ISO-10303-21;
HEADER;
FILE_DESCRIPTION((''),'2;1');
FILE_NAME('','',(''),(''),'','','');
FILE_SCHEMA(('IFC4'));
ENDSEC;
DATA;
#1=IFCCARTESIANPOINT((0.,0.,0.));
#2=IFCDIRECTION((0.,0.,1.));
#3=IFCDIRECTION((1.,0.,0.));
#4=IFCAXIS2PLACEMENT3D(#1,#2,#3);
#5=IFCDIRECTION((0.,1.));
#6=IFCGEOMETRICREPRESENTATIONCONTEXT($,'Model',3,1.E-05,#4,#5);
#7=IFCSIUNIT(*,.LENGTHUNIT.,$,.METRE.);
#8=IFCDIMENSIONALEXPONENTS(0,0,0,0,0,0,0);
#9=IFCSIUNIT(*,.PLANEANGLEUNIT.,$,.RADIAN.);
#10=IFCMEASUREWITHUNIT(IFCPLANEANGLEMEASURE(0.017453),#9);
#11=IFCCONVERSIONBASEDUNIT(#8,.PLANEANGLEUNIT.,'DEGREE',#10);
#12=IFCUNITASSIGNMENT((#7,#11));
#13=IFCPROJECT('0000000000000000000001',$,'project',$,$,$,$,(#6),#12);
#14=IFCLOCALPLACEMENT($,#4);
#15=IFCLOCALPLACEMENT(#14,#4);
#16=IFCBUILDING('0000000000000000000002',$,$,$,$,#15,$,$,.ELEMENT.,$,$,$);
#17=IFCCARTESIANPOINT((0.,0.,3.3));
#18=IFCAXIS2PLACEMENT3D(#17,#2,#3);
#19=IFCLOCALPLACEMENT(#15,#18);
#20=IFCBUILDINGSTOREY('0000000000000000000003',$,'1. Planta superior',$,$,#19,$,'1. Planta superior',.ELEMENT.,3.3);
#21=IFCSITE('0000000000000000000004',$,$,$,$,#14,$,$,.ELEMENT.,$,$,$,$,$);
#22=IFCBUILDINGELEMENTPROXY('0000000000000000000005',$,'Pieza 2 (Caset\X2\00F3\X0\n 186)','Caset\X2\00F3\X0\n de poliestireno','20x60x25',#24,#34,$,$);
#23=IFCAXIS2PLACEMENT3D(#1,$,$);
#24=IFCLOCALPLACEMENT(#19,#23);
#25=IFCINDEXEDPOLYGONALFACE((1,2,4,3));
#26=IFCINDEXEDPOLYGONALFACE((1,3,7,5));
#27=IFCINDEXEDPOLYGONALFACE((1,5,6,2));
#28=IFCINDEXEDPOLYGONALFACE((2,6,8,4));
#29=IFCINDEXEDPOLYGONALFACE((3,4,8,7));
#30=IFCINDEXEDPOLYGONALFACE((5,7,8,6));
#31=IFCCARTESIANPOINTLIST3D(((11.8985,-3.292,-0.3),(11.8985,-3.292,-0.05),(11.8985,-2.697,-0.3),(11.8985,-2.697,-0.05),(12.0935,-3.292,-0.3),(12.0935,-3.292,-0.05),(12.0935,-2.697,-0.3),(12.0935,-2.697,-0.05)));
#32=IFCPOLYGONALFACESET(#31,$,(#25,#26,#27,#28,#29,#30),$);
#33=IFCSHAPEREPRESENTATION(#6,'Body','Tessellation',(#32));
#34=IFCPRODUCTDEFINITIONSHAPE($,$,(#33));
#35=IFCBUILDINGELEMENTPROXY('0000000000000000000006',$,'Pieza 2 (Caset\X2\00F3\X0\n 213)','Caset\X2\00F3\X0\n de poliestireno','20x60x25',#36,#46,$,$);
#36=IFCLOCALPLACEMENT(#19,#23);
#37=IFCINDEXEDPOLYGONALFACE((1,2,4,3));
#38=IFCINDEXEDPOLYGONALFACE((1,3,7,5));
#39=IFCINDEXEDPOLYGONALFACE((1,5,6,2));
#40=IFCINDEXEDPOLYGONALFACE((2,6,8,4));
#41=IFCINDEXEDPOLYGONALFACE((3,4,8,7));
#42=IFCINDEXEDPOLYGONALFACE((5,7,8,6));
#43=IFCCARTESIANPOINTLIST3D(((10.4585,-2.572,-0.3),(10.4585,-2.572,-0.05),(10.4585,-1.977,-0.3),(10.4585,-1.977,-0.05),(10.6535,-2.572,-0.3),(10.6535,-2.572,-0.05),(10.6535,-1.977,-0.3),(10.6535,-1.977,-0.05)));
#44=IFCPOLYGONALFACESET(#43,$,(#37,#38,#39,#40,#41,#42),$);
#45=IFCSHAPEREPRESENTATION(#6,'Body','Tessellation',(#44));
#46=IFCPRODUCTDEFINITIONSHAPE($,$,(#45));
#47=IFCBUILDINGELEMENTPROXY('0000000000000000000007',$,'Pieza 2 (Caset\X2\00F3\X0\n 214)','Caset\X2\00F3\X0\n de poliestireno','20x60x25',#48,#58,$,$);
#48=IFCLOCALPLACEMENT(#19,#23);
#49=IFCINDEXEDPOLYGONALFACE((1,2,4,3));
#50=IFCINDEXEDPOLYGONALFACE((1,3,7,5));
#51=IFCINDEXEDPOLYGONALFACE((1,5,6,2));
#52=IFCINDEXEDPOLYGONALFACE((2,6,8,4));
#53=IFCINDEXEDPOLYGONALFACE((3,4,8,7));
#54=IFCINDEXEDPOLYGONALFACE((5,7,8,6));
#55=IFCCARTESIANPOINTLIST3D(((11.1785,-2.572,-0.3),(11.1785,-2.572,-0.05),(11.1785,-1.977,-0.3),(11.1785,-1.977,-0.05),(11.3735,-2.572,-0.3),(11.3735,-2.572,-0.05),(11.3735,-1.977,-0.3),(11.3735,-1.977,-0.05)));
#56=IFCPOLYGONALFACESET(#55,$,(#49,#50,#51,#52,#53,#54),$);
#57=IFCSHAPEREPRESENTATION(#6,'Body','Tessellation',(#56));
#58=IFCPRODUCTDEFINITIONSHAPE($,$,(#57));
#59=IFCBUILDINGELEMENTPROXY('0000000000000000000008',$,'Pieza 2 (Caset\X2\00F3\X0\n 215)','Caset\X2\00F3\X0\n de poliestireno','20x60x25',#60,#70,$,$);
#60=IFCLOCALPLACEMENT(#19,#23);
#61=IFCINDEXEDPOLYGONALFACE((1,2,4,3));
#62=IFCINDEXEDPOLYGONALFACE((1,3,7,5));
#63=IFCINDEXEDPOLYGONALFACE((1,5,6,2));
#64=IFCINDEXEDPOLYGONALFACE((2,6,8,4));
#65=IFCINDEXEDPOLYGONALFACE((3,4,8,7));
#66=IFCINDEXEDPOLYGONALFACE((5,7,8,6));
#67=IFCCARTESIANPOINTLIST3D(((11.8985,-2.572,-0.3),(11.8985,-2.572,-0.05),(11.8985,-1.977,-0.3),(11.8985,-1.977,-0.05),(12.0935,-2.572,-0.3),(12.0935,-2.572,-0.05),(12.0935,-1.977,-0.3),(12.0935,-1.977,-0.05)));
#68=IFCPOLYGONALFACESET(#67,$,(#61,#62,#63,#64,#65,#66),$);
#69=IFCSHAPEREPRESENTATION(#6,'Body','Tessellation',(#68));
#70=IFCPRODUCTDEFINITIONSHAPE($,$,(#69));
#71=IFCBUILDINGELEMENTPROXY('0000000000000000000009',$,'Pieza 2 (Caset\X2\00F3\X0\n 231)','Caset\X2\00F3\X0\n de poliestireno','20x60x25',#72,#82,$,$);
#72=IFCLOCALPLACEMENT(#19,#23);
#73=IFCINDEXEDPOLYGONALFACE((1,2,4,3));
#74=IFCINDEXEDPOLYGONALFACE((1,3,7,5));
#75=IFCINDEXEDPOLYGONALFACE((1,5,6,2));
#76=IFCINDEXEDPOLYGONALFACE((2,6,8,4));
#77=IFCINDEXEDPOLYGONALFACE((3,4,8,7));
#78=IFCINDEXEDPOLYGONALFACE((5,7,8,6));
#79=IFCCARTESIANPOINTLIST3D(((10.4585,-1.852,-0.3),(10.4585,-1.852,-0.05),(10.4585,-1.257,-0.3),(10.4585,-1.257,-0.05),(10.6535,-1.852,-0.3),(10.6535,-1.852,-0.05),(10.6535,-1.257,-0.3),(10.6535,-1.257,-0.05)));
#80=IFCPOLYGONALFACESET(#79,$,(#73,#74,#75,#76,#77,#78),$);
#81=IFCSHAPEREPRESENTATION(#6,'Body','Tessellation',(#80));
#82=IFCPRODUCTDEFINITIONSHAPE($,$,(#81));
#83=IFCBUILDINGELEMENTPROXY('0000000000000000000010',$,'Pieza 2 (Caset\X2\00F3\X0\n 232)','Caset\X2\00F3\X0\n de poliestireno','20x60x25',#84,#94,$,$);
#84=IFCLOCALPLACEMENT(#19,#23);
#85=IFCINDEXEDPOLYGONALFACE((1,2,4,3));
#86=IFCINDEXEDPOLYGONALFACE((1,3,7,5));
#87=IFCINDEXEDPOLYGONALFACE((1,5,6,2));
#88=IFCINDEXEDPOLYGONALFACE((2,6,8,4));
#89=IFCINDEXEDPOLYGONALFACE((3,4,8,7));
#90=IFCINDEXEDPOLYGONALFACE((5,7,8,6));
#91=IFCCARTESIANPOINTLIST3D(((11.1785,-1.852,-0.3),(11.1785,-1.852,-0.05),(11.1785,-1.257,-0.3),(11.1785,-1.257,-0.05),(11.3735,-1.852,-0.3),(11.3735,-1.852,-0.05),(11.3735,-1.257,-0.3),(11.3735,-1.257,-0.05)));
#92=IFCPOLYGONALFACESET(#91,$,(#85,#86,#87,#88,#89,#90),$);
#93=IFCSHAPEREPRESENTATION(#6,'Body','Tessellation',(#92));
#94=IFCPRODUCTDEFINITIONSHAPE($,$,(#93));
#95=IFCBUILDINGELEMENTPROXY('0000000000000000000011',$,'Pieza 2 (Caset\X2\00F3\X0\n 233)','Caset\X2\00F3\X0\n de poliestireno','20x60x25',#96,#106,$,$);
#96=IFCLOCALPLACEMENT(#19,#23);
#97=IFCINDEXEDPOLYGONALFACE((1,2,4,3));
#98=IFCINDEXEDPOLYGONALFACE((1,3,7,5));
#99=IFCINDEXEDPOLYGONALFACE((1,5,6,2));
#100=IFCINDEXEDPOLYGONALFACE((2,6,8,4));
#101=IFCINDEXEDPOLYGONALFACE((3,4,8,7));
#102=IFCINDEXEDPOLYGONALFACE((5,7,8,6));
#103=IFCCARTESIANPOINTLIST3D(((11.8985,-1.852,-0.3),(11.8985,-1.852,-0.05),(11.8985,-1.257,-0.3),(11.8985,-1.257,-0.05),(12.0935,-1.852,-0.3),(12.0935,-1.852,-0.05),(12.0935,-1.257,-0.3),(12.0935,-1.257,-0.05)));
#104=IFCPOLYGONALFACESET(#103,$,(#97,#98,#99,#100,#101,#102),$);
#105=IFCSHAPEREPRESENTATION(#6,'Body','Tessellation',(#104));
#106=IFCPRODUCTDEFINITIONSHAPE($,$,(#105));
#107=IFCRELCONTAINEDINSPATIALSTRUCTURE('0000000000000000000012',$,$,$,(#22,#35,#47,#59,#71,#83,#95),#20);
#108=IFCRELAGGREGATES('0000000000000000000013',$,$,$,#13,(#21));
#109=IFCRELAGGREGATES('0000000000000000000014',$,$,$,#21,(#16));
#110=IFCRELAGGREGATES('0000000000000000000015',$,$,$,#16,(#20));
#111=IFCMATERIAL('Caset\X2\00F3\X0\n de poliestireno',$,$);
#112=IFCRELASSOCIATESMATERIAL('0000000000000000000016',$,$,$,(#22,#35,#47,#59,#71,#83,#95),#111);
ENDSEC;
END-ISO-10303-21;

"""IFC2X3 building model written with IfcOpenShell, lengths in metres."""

from ifc_helpers import new_model, entity, si_unit, converted_unit, direction, frame, origin_with_axes, origin_2d_with_axis, place, context, project, spatial, rectangle, extrude, source, transform, mapped, material, element, save


model = new_model("IFC2X3")

# Units and contexts
model_context = context("Model", 3, precision=1e-05, world=origin_with_axes(), true_north=direction((0.0, 1.0)))
ifc_project = project(units=[si_unit("LENGTHUNIT", "METRE"), converted_unit("PLANEANGLEUNIT", "DEGREE", entity("IfcPlaneAngleMeasure", 0.017453), si_unit("PLANEANGLEUNIT", "RADIAN"), dimensions=[0, 0, 0, 0, 0, 0, 0])], contexts=[model_context])

# Site, building, storey
site_placement = place(None, origin_with_axes())
site = spatial("IfcSite", under=ifc_project, at=site_placement, CompositionType="ELEMENT")
building_placement = place(site_placement, origin_with_axes())
building = spatial("IfcBuilding", under=site, at=building_placement, CompositionType="ELEMENT")
storey_placement = place(building_placement, frame((0.0, 0.0, 3.3), z_axis=(0.0, 0.0, 1.0), x_axis=(1.0, 0.0, 0.0)))
storey = spatial("IfcBuildingStorey", under=building, at=storey_placement, Name="1. Planta superior", LongName="1. Planta superior", CompositionType="ELEMENT", Elevation=3.3)

# Building element proxies
ifc_material = material(Name="Casetón de poliestireno")
shared_shape = source(origin_with_axes(), model_context, "Body", "SweptSolid", [
    extrude(rectangle(XDim=0.195, YDim=0.25, at=origin_2d_with_axis()), origin_with_axes(), (0.0, 0.0, 1.0), 0.595),
])
placement_1 = place(storey_placement, frame((11.996, -3.292, -0.175), z_axis=(0.0, 1.0, 0.0), x_axis=(-1.0, 0.0, 0.0)))
for number, where, z_axis, x_axis, name in (
    (1, (0.0, 0.0, 0.0), (0.0, 0.0, 1.0), (1.0, 0.0, 0.0), "Pieza 2 (Casetón 186)"),
):
    element("IfcBuildingElementProxy", number, at=place(placement_1, frame(where, z_axis=z_axis, x_axis=x_axis)), inside=storey, material=ifc_material, Name=name, Description="Casetón de poliestireno", ObjectType="20x60x25", context=model_context, shape_type="MappedRepresentation", body=[
        mapped(shared_shape, transform((0.0, 0.0, 0.0), x_axis=(1.0, 0.0, 0.0), y_axis=(0.0, 1.0, 0.0), z_axis=(0.0, 0.0, 1.0))),
    ])
placement_2 = place(storey_placement, frame((10.556, -2.572, -0.175), z_axis=(0.0, 1.0, 0.0), x_axis=(-1.0, 0.0, 0.0)))
for number, where, z_axis, x_axis, name in (
    (2, (0.0, 0.0, 0.0), (0.0, 0.0, 1.0), (1.0, 0.0, 0.0), "Pieza 2 (Casetón 213)"),
):
    element("IfcBuildingElementProxy", number, at=place(placement_2, frame(where, z_axis=z_axis, x_axis=x_axis)), inside=storey, material=ifc_material, Name=name, Description="Casetón de poliestireno", ObjectType="20x60x25", context=model_context, shape_type="MappedRepresentation", body=[
        mapped(shared_shape, transform((0.0, 0.0, 0.0), x_axis=(1.0, 0.0, 0.0), y_axis=(0.0, 1.0, 0.0), z_axis=(0.0, 0.0, 1.0))),
    ])
placement_3 = place(storey_placement, frame((11.276, -2.572, -0.175), z_axis=(0.0, 1.0, 0.0), x_axis=(-1.0, 0.0, 0.0)))
for number, where, z_axis, x_axis, name in (
    (3, (0.0, 0.0, 0.0), (0.0, 0.0, 1.0), (1.0, 0.0, 0.0), "Pieza 2 (Casetón 214)"),
):
    element("IfcBuildingElementProxy", number, at=place(placement_3, frame(where, z_axis=z_axis, x_axis=x_axis)), inside=storey, material=ifc_material, Name=name, Description="Casetón de poliestireno", ObjectType="20x60x25", context=model_context, shape_type="MappedRepresentation", body=[
        mapped(shared_shape, transform((0.0, 0.0, 0.0), x_axis=(1.0, 0.0, 0.0), y_axis=(0.0, 1.0, 0.0), z_axis=(0.0, 0.0, 1.0))),
    ])
placement_4 = place(storey_placement, frame((11.996, -2.572, -0.175), z_axis=(0.0, 1.0, 0.0), x_axis=(-1.0, 0.0, 0.0)))
for number, where, z_axis, x_axis, name in (
    (4, (0.0, 0.0, 0.0), (0.0, 0.0, 1.0), (1.0, 0.0, 0.0), "Pieza 2 (Casetón 215)"),
):
    element("IfcBuildingElementProxy", number, at=place(placement_4, frame(where, z_axis=z_axis, x_axis=x_axis)), inside=storey, material=ifc_material, Name=name, Description="Casetón de poliestireno", ObjectType="20x60x25", context=model_context, shape_type="MappedRepresentation", body=[
        mapped(shared_shape, transform((0.0, 0.0, 0.0), x_axis=(1.0, 0.0, 0.0), y_axis=(0.0, 1.0, 0.0), z_axis=(0.0, 0.0, 1.0))),
    ])
placement_5 = place(storey_placement, frame((10.556, -1.852, -0.175), z_axis=(0.0, 1.0, 0.0), x_axis=(-1.0, 0.0, 0.0)))
for number, where, z_axis, x_axis, name in (
    (5, (0.0, 0.0, 0.0), (0.0, 0.0, 1.0), (1.0, 0.0, 0.0), "Pieza 2 (Casetón 231)"),
):
    element("IfcBuildingElementProxy", number, at=place(placement_5, frame(where, z_axis=z_axis, x_axis=x_axis)), inside=storey, material=ifc_material, Name=name, Description="Casetón de poliestireno", ObjectType="20x60x25", context=model_context, shape_type="MappedRepresentation", body=[
        mapped(shared_shape, transform((0.0, 0.0, 0.0), x_axis=(1.0, 0.0, 0.0), y_axis=(0.0, 1.0, 0.0), z_axis=(0.0, 0.0, 1.0))),
    ])
placement_6 = place(storey_placement, frame((11.276, -1.852, -0.175), z_axis=(0.0, 1.0, 0.0), x_axis=(-1.0, 0.0, 0.0)))
for number, where, z_axis, x_axis, name in (
    (6, (0.0, 0.0, 0.0), (0.0, 0.0, 1.0), (1.0, 0.0, 0.0), "Pieza 2 (Casetón 232)"),
):
    element("IfcBuildingElementProxy", number, at=place(placement_6, frame(where, z_axis=z_axis, x_axis=x_axis)), inside=storey, material=ifc_material, Name=name, Description="Casetón de poliestireno", ObjectType="20x60x25", context=model_context, shape_type="MappedRepresentation", body=[
        mapped(shared_shape, transform((0.0, 0.0, 0.0), x_axis=(1.0, 0.0, 0.0), y_axis=(0.0, 1.0, 0.0), z_axis=(0.0, 0.0, 1.0))),
    ])
placement_7 = place(storey_placement, frame((11.996, -1.852, -0.175), z_axis=(0.0, 1.0, 0.0), x_axis=(-1.0, 0.0, 0.0)))
for number, where, z_axis, x_axis, name in (
    (7, (0.0, 0.0, 0.0), (0.0, 0.0, 1.0), (1.0, 0.0, 0.0), "Pieza 2 (Casetón 233)"),
):
    element("IfcBuildingElementProxy", number, at=place(placement_7, frame(where, z_axis=z_axis, x_axis=x_axis)), inside=storey, material=ifc_material, Name=name, Description="Casetón de poliestireno", ObjectType="20x60x25", context=model_context, shape_type="MappedRepresentation", body=[
        mapped(shared_shape, transform((0.0, 0.0, 0.0), x_axis=(1.0, 0.0, 0.0), y_axis=(0.0, 1.0, 0.0), z_axis=(0.0, 0.0, 1.0))),
    ])

save(model, "model.ifc")
